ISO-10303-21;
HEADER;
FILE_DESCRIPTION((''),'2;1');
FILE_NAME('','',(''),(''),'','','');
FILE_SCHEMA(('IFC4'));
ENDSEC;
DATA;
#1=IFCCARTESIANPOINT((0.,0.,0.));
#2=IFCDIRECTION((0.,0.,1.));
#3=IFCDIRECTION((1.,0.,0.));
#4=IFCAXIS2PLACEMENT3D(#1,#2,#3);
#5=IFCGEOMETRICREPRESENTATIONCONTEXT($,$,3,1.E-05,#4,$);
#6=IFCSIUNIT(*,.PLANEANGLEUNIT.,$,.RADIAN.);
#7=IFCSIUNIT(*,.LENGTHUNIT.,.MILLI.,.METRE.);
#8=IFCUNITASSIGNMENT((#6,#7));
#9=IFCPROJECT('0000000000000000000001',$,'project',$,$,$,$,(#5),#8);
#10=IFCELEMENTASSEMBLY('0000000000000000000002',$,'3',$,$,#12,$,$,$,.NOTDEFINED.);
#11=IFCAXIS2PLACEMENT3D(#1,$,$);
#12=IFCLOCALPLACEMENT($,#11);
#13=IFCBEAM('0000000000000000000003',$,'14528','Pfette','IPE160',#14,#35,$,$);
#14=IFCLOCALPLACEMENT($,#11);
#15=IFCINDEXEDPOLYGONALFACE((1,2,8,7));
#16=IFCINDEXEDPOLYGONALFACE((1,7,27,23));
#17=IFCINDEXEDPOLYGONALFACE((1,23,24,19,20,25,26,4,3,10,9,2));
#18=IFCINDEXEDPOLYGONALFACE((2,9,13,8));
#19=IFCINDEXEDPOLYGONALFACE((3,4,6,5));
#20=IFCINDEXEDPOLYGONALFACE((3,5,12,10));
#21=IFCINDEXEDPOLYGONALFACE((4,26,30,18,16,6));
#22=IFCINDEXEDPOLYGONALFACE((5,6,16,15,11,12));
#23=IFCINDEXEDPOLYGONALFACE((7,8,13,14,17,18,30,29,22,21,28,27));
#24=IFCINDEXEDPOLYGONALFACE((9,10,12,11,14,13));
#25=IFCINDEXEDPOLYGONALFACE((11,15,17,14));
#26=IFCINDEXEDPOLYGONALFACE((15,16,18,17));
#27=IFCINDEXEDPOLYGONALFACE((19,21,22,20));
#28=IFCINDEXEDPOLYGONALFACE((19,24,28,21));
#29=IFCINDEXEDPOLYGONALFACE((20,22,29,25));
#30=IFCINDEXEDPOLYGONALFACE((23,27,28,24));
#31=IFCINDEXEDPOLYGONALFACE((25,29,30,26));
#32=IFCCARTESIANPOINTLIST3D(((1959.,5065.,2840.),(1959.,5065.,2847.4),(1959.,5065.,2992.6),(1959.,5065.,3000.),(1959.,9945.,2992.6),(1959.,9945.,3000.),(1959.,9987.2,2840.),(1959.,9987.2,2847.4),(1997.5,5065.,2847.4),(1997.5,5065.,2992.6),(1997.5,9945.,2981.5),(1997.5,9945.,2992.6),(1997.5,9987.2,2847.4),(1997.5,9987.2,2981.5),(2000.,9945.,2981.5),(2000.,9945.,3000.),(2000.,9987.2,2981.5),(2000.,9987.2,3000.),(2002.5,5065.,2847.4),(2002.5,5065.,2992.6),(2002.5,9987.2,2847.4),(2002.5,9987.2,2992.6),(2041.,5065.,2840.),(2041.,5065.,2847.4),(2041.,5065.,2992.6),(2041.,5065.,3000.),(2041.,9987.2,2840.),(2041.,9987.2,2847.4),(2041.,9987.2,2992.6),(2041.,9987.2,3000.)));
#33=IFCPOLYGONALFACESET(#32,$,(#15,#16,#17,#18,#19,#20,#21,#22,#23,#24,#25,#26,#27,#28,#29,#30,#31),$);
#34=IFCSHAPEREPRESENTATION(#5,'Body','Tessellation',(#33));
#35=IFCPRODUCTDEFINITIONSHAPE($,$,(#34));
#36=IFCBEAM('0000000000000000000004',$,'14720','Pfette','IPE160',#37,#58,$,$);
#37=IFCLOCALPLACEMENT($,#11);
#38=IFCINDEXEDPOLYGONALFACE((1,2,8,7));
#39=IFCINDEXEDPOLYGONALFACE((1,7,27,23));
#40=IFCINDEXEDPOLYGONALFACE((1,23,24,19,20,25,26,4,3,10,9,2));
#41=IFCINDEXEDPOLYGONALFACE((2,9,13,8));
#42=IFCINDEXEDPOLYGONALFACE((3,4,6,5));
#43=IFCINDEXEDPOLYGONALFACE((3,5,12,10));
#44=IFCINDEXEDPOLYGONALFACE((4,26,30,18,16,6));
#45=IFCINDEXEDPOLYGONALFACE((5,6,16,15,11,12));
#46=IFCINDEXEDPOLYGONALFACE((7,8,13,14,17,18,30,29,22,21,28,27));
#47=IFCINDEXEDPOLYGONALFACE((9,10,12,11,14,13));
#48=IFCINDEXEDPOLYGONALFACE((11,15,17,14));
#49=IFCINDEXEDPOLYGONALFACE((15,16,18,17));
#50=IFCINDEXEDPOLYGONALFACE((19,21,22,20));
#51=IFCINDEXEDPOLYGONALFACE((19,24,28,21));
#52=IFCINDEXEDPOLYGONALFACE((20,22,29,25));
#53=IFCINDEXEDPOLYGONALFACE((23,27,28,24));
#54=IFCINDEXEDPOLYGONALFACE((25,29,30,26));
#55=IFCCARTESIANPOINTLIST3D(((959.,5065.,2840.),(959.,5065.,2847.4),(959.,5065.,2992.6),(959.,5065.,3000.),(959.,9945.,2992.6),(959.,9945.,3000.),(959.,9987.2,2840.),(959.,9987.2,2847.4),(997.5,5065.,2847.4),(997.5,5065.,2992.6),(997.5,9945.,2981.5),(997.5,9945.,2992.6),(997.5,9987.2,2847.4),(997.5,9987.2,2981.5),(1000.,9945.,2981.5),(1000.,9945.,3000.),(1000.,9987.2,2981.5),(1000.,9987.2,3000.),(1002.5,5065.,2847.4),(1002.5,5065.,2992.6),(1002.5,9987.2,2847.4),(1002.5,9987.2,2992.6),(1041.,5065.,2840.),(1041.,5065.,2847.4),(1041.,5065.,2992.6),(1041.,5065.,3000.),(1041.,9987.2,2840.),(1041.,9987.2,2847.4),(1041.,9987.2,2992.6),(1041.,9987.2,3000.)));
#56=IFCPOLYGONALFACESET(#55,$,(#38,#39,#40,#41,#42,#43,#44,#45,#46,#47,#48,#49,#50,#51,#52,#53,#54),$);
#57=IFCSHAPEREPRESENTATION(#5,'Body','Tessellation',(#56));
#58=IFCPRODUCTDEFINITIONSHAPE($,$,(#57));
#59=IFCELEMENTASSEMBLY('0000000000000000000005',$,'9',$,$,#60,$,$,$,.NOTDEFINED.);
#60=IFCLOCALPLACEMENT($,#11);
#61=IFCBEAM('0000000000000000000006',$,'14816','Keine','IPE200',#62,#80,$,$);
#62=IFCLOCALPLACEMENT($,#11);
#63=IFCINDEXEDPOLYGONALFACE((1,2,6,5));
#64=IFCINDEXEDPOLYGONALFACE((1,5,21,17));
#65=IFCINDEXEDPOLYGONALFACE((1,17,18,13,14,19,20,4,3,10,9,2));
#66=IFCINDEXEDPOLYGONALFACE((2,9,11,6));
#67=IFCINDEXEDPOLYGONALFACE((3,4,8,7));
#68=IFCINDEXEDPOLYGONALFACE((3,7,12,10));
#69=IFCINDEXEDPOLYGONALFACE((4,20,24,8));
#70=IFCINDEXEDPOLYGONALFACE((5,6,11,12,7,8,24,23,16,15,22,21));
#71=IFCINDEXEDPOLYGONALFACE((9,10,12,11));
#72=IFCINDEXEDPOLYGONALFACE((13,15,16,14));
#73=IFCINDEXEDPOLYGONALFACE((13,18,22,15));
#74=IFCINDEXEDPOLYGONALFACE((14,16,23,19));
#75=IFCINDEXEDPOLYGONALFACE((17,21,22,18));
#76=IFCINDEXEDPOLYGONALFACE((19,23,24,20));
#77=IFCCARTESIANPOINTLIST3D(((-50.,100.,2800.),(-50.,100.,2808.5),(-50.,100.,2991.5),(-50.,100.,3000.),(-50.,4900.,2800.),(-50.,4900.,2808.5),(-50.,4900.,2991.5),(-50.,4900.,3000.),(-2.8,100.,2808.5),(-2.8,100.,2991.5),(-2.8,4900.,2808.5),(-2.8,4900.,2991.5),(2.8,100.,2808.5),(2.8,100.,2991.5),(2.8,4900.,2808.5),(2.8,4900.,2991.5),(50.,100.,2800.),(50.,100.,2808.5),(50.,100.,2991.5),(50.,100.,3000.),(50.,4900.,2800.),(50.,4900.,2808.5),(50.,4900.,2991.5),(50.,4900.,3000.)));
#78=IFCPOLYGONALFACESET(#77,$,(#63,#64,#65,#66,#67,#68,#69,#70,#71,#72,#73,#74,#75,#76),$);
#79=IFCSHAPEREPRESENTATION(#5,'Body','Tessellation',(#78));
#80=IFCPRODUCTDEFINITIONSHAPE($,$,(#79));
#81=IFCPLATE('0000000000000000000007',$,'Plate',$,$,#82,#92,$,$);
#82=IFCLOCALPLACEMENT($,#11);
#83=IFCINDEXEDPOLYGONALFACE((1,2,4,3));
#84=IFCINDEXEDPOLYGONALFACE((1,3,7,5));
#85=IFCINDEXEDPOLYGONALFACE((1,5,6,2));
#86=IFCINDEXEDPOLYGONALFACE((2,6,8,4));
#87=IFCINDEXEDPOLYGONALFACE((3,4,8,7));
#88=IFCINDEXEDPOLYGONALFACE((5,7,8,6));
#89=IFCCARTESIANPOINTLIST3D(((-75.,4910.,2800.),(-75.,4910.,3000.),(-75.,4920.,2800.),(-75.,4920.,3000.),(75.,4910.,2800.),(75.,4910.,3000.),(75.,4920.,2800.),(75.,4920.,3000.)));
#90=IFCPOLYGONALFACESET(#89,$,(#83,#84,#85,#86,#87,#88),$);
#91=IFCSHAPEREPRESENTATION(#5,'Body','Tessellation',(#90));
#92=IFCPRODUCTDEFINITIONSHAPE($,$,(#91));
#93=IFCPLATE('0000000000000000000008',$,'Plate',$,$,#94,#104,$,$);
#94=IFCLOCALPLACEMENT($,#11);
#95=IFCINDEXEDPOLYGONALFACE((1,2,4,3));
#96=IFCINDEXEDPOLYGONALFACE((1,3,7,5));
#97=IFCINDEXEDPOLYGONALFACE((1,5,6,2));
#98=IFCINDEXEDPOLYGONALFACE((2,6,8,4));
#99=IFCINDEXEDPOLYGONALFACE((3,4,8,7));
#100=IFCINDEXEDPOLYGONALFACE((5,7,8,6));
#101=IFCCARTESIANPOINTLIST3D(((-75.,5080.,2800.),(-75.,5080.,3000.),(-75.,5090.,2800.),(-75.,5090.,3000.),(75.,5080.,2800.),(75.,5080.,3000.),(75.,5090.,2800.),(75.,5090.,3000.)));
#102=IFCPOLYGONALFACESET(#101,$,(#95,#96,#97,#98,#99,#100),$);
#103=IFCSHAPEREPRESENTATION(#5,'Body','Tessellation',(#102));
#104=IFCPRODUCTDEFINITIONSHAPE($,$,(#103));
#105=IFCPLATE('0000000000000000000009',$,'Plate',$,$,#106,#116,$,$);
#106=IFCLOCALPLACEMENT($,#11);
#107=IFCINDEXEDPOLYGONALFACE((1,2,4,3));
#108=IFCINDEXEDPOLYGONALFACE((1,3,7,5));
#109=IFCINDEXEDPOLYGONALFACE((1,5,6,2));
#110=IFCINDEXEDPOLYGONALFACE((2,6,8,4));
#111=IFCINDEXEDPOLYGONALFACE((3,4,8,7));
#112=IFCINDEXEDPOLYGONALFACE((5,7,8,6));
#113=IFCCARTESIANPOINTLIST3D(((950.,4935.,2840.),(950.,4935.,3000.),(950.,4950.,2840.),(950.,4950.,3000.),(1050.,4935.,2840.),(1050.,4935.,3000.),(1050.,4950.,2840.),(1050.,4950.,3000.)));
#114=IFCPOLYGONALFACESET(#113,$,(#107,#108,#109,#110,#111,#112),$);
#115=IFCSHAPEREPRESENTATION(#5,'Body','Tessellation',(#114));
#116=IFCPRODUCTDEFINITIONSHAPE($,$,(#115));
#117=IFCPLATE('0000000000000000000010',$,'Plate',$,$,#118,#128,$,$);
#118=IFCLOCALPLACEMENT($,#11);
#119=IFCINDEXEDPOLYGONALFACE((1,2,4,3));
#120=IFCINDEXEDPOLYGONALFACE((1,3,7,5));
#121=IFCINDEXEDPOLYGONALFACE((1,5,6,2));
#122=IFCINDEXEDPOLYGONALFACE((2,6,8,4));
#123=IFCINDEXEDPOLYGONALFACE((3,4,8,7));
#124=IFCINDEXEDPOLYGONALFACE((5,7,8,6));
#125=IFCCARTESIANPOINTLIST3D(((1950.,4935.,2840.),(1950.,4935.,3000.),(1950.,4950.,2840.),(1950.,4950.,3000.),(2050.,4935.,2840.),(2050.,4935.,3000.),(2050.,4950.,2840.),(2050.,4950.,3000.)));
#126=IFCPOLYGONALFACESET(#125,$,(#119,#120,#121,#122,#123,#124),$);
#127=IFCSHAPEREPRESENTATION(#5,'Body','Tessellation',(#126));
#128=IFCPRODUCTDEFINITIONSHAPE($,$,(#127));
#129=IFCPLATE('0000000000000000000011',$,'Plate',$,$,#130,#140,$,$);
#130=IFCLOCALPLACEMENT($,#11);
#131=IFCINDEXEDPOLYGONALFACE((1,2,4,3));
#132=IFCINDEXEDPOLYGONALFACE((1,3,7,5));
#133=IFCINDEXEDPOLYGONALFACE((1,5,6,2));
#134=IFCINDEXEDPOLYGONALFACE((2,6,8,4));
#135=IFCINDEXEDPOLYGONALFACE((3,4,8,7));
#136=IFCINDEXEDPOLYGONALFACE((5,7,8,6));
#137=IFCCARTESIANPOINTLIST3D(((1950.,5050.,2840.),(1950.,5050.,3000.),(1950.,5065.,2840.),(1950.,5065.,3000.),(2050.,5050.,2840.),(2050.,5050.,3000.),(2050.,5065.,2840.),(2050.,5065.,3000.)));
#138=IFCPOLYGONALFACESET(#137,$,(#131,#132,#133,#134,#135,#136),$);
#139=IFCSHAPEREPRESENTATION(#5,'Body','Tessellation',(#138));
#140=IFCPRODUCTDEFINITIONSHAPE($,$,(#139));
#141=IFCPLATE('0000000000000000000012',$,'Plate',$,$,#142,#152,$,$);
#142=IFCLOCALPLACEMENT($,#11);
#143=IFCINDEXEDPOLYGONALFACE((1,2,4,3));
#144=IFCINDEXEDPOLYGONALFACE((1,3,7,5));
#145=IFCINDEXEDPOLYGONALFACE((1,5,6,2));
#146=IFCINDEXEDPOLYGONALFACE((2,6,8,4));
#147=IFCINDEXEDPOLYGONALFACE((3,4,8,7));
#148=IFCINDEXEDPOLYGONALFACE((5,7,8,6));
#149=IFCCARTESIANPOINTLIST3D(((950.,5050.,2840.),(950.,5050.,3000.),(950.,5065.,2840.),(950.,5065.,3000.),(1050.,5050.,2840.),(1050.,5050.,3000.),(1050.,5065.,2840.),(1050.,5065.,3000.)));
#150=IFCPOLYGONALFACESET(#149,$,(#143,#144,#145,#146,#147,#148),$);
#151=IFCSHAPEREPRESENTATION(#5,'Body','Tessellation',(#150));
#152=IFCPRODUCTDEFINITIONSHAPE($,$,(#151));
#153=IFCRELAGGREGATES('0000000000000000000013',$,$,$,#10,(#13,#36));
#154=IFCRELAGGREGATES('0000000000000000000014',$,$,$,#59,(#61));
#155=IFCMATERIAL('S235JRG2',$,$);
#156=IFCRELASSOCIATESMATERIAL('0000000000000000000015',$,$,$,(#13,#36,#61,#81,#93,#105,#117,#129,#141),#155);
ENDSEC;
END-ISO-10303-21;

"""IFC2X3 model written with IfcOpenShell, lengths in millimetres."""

from ifc_helpers import new_model, si_unit, point, frame, origin_with_axes, place, context, project, polyline, line_curve, trimmed, segment, composite_curve, outline, extrude, clip, halfspace, material, element, aggregate, save


model = new_model("IFC2X3")

# Units and contexts
context_of_model = context(None, 3, precision=1e-05, world=origin_with_axes())
ifc_project = project(units=[si_unit("PLANEANGLEUNIT", "RADIAN"), si_unit("LENGTHUNIT", "METRE", prefix="MILLI")], contexts=[context_of_model])

# Element assembly, beams, openings
ifc_material = material(Name="S235JRG2")
assembly_1_placement = place(None, frame((1000.0, 5002.5, 6000.0), z_axis=(0.0, 0.0, 1.0), x_axis=(0.0, 1.0, 0.0)))
assembly_1 = element("IfcElementAssembly", 1, at=assembly_1_placement, Name="3", PredefinedType="NOTDEFINED")
placement_1 = place(None, frame((2000.0, 5002.5, 2920.0), z_axis=(0.0, 0.0, 1.0), x_axis=(0.0, 1.0, 0.0)))
beam_1_placement = place(placement_1, origin_with_axes())
beam_1 = element("IfcBeam", 2, at=beam_1_placement, material=ifc_material, Name="14528", Description="Pfette", ObjectType="IPE160", context=context_of_model, shape_type="Clipping", body=[
    clip(clip(extrude(outline(polyline([(41.0, -80.0), (41.0, -72.6), (2.5, -72.6), (2.5, 72.6), (41.0, 72.6), (41.0, 80.0), (-41.0, 80.0), (-41.0, 72.6), (-2.5, 72.6), (-2.5, -72.6), (-41.0, -72.6), (-41.0, -80.0), (41.0, -80.0), (41.0, -80.0)])), frame((0.0, 0.0, 0.0), z_axis=(1.0, 0.0, 0.0), x_axis=(0.0, 1.0, 0.0)), (0.0, 0.0, 1.0), 4997.5), halfspace(frame((62.5, 0.0, 80.0), z_axis=(-1.0, 0.0, 0.0), x_axis=(0.0, 0.0, -1.0)), False)), halfspace(frame((4984.7, 0.0, 80.0), z_axis=(1.0, 0.0, 0.0), x_axis=(0.0, 0.0, 1.0)), False)),
])
opening_1_placement = place(beam_1_placement, frame((4942.5, 0.0, 61.5), z_axis=(0.0, 1.0, 0.0), x_axis=(-1.0, 0.0, 0.0)))
element("IfcOpeningElement", 3, at=opening_1_placement, cuts=beam_1, ObjectType="Recess", context=context_of_model, shape_type="SweptSolid", body=[
    extrude(outline(composite_curve([segment(trimmed(line_curve((0.0, 0.0), (0.0, 1.0, 0.0), 18.501), [point((0.0, 0.0))], [point((0.0, 18.5))], True, "CARTESIAN"), True, "CONTINUOUS"), segment(trimmed(line_curve((0.0, 18.5), (-1.0, 0.0, 0.0), 42.201), [point((0.0, 18.5))], [point((-42.2, 18.5))], True, "CARTESIAN"), True, "CONTINUOUS"), segment(trimmed(line_curve((-42.2, 18.5), (0.0, -1.0, 0.0), 18.501), [point((-42.2, 18.5))], [point((-42.2, 0.0))], True, "CARTESIAN"), True, "CONTINUOUS"), segment(trimmed(line_curve((-42.2, 0.0), (1.0, 0.0, 0.0), 42.201), [point((-42.2, 0.0))], [point((0.0, 0.0))], True, "CARTESIAN"), True, "CONTINUOUS")], self_intersect=False)), origin_with_axes(), (0.0, 0.0, 1.0), 3000.0),
])
placement_2 = place(None, frame((1000.0, 5002.5, 2920.0), z_axis=(0.0, 0.0, 1.0), x_axis=(0.0, 1.0, 0.0)))
beam_2_placement = place(placement_2, origin_with_axes())
beam_2 = element("IfcBeam", 4, at=beam_2_placement, material=ifc_material, Name="14720", Description="Pfette", ObjectType="IPE160", context=context_of_model, shape_type="Clipping", body=[
    clip(clip(extrude(outline(polyline([(41.0, -80.0), (41.0, -72.6), (2.5, -72.6), (2.5, 72.6), (41.0, 72.6), (41.0, 80.0), (-41.0, 80.0), (-41.0, 72.6), (-2.5, 72.6), (-2.5, -72.6), (-41.0, -72.6), (-41.0, -80.0), (41.0, -80.0), (41.0, -80.0)])), frame((0.0, 0.0, 0.0), z_axis=(1.0, 0.0, 0.0), x_axis=(0.0, 1.0, 0.0)), (0.0, 0.0, 1.0), 4997.5), halfspace(frame((62.5, 0.0, 80.0), z_axis=(-1.0, 0.0, 0.0), x_axis=(0.0, 0.0, -1.0)), False)), halfspace(frame((4984.7, 0.0, 80.0), z_axis=(1.0, 0.0, 0.0), x_axis=(0.0, 0.0, 1.0)), False)),
])
opening_2_placement = place(beam_2_placement, frame((4942.5, 0.0, 61.5), z_axis=(0.0, 1.0, 0.0), x_axis=(-1.0, 0.0, 0.0)))
element("IfcOpeningElement", 5, at=opening_2_placement, cuts=beam_2, ObjectType="Recess", context=context_of_model, shape_type="SweptSolid", body=[
    extrude(outline(composite_curve([segment(trimmed(line_curve((0.0, 0.0), (0.0, 1.0, 0.0), 18.501), [point((0.0, 0.0))], [point((0.0, 18.5))], True, "CARTESIAN"), True, "CONTINUOUS"), segment(trimmed(line_curve((0.0, 18.5), (-1.0, 0.0, 0.0), 42.201), [point((0.0, 18.5))], [point((-42.2, 18.5))], True, "CARTESIAN"), True, "CONTINUOUS"), segment(trimmed(line_curve((-42.2, 18.5), (0.0, -1.0, 0.0), 18.501), [point((-42.2, 18.5))], [point((-42.2, 0.0))], True, "CARTESIAN"), True, "CONTINUOUS"), segment(trimmed(line_curve((-42.2, 0.0), (1.0, 0.0, 0.0), 42.201), [point((-42.2, 0.0))], [point((0.0, 0.0))], True, "CARTESIAN"), True, "CONTINUOUS")], self_intersect=False)), origin_with_axes(), (0.0, 0.0, 1.0), 3000.0),
])
aggregate(assembly_1, [beam_1, beam_2])

# Element assembly, beam
assembly_2_placement = place(None, frame((5000.0, 10000.0, 6000.0), z_axis=(0.0, 0.0, 1.0), x_axis=(0.0, -1.0, 0.0)))
assembly_2 = element("IfcElementAssembly", 6, at=assembly_2_placement, Name="9", PredefinedType="NOTDEFINED")
placement_3 = place(None, frame((0.0, 5000.0, 2900.0), z_axis=(0.0, 0.0, 1.0), x_axis=(0.0, -1.0, 0.0)))
beam_3_placement = place(placement_3, origin_with_axes())
beam_3 = element("IfcBeam", 7, at=beam_3_placement, material=ifc_material, Name="14816", Description="Keine", ObjectType="IPE200", context=context_of_model, shape_type="Clipping", body=[
    clip(clip(extrude(outline(polyline([(50.0, -100.0), (50.0, -91.5), (2.8, -91.5), (2.8, 91.5), (50.0, 91.5), (50.0, 100.0), (-50.0, 100.0), (-50.0, 91.5), (-2.8, 91.5), (-2.8, -91.5), (-50.0, -91.5), (-50.0, -100.0), (50.0, -100.0), (50.0, -100.0)])), frame((0.0, 0.0, 0.0), z_axis=(1.0, 0.0, 0.0), x_axis=(0.0, 1.0, 0.0)), (0.0, 0.0, 1.0), 5000.0), halfspace(frame((4900.0, 0.0, 100.0), z_axis=(1.0, 0.0, 0.0), x_axis=(0.0, 0.0, 1.0)), False)), halfspace(frame((100.0, 0.0, 100.0), z_axis=(-1.0, 0.0, 0.0), x_axis=(0.0, 0.0, -1.0)), False)),
])
aggregate(assembly_2, [beam_3])

# Plates
placement_4 = place(None, origin_with_axes())
plate_1_placement = place(placement_4, frame((75.0, 4920.0, 3000.0), z_axis=(0.0, 0.0, -1.0), x_axis=(0.0, -1.0, 0.0)))
element("IfcPlate", 8, at=plate_1_placement, material=ifc_material, Name="Plate", context=context_of_model, shape_type="SweptSolid", body=[
    extrude(outline(polyline([(0.0, 0.0), (150.0, 0.0), (150.0, 200.0), (0.0, 200.0), (0.0, 0.0)])), frame((0.0, 0.0, 0.0), z_axis=(1.0, 0.0, 0.0), x_axis=(0.0, 1.0, 0.0)), (0.0, 0.0, 1.0), 10.0),
])
placement_5 = place(None, origin_with_axes())
plate_2_placement = place(placement_5, frame((-75.0, 5080.0, 3000.0), z_axis=(0.0, 0.0, -1.0), x_axis=(0.0, 1.0, 0.0)))
element("IfcPlate", 9, at=plate_2_placement, material=ifc_material, Name="Plate", context=context_of_model, shape_type="SweptSolid", body=[
    extrude(outline(polyline([(0.0, 0.0), (150.0, 0.0), (150.0, 200.0), (0.0, 200.0), (0.0, 0.0)])), frame((0.0, 0.0, 0.0), z_axis=(1.0, 0.0, 0.0), x_axis=(0.0, 1.0, 0.0)), (0.0, 0.0, 1.0), 10.0),
])
placement_6 = place(None, origin_with_axes())
plate_3_placement = place(placement_6, frame((950.0, 4935.0, 2840.0), z_axis=(1.0, 0.0, 0.0), x_axis=(0.0, 1.0, 0.0)))
element("IfcPlate", 10, at=plate_3_placement, material=ifc_material, Name="Plate", context=context_of_model, shape_type="SweptSolid", body=[
    extrude(outline(polyline([(0.0, 0.0), (160.0, 0.0), (160.0, 100.0), (0.0, 100.0), (0.0, 0.0)])), frame((0.0, 0.0, 0.0), z_axis=(1.0, 0.0, 0.0), x_axis=(0.0, 1.0, 0.0)), (0.0, 0.0, 1.0), 15.0),
])
placement_7 = place(None, origin_with_axes())
plate_4_placement = place(placement_7, frame((1950.0, 4935.0, 2840.0), z_axis=(1.0, 0.0, 0.0), x_axis=(0.0, 1.0, 0.0)))
element("IfcPlate", 11, at=plate_4_placement, material=ifc_material, Name="Plate", context=context_of_model, shape_type="SweptSolid", body=[
    extrude(outline(polyline([(0.0, 0.0), (160.0, 0.0), (160.0, 100.0), (0.0, 100.0), (0.0, 0.0)])), frame((0.0, 0.0, 0.0), z_axis=(1.0, 0.0, 0.0), x_axis=(0.0, 1.0, 0.0)), (0.0, 0.0, 1.0), 15.0),
])
placement_8 = place(None, origin_with_axes())
plate_5_placement = place(placement_8, frame((2050.0, 5065.0, 2840.0), z_axis=(-1.0, 0.0, 0.0), x_axis=(0.0, -1.0, 0.0)))
element("IfcPlate", 12, at=plate_5_placement, material=ifc_material, Name="Plate", context=context_of_model, shape_type="SweptSolid", body=[
    extrude(outline(polyline([(0.0, 0.0), (160.0, 0.0), (160.0, 100.0), (0.0, 100.0), (0.0, 0.0)])), frame((0.0, 0.0, 0.0), z_axis=(1.0, 0.0, 0.0), x_axis=(0.0, 1.0, 0.0)), (0.0, 0.0, 1.0), 15.0),
])
placement_9 = place(None, origin_with_axes())
plate_6_placement = place(placement_9, frame((1050.0, 5065.0, 2840.0), z_axis=(-1.0, 0.0, 0.0), x_axis=(0.0, -1.0, 0.0)))
element("IfcPlate", 13, at=plate_6_placement, material=ifc_material, Name="Plate", context=context_of_model, shape_type="SweptSolid", body=[
    extrude(outline(polyline([(0.0, 0.0), (160.0, 0.0), (160.0, 100.0), (0.0, 100.0), (0.0, 0.0)])), frame((0.0, 0.0, 0.0), z_axis=(1.0, 0.0, 0.0), x_axis=(0.0, 1.0, 0.0)), (0.0, 0.0, 1.0), 15.0),
])

save(model, "model.ifc")
